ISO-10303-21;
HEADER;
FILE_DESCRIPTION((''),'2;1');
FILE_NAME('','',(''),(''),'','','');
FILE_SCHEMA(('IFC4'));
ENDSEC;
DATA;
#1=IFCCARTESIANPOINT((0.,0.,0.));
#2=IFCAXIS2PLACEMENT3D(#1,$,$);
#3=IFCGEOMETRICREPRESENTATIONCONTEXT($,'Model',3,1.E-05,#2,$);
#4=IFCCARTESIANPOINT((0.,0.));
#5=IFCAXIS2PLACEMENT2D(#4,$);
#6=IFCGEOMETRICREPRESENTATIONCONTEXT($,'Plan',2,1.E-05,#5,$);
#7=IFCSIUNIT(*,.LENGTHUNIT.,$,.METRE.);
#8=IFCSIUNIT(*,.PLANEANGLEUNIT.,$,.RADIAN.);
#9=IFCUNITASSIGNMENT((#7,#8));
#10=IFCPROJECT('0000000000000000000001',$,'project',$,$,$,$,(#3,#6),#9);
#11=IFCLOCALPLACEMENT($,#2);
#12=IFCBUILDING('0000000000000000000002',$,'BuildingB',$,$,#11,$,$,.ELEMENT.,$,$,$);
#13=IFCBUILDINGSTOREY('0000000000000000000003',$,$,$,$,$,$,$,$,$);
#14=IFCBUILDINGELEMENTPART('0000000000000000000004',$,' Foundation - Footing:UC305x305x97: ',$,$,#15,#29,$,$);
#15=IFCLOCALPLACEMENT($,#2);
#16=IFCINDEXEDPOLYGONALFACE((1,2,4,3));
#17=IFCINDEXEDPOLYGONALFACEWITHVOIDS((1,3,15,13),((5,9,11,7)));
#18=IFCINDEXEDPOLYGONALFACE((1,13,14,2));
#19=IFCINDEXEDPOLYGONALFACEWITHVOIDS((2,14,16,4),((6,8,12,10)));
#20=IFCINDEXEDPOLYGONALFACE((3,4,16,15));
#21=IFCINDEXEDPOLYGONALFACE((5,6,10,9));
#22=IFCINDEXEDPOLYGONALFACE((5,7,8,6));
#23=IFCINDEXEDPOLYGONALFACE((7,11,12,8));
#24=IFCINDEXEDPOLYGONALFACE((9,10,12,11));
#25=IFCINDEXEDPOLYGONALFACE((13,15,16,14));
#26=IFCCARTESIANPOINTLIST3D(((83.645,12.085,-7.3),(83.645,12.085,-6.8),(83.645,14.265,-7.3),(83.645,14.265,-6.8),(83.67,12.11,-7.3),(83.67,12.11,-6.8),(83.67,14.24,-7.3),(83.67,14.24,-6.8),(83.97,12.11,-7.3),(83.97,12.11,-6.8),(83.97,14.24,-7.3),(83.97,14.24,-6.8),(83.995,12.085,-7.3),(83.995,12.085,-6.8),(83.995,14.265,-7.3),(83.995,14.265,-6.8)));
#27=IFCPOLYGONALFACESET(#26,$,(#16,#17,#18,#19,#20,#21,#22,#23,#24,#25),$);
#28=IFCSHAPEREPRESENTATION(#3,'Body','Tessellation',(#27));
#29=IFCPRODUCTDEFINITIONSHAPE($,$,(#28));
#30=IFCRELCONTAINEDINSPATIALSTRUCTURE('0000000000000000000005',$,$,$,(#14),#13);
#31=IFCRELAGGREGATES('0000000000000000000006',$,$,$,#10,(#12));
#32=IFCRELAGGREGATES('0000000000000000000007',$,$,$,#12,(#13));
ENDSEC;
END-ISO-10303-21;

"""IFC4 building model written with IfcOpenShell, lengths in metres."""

from ifc_helpers import new_model, si_unit, origin, origin_2d, place, context, project, spatial, polyline, outline, extrude, element, save


model = new_model("IFC4")

# Units and contexts
model_context = context("Model", 3, precision=1e-05, world=origin())
plan_context = context("Plan", 2, precision=1e-05, world=origin_2d())
ifc_project = project(units=[si_unit("LENGTHUNIT", "METRE"), si_unit("PLANEANGLEUNIT", "RADIAN")], contexts=[model_context, plan_context])

# Building, storey
building_placement = place(None, origin())
building = spatial("IfcBuilding", under=ifc_project, at=building_placement, Name="BuildingB", CompositionType="ELEMENT")
storey = spatial("IfcBuildingStorey", under=building)

# Building element part, opening
building_element_part_1 = element("IfcBuildingElementPart", 1, inside=storey, Name=" Foundation - Footing:UC305x305x97: ", context=model_context, shape_type="SweptSolid", body=[
    extrude(outline(polyline([(83.995, 12.085, -7.3), (83.645, 12.085, -7.3), (83.645, 14.265, -7.3), (83.995, 14.265, -7.3), (83.995, 12.085, -7.3)])), None, (0.0, 0.0, 1.0), 0.5),
])
element("IfcOpeningElement", 2, inside=storey, cuts=building_element_part_1, context=model_context, shape_type="SweptSolid", body=[
    extrude(outline(polyline([(83.97, 12.11, -7.3), (83.67, 12.11, -7.3), (83.67, 14.24, -7.3), (83.97, 14.24, -7.3), (83.97, 12.11, -7.3)])), None, (0.0, 0.0, 1.0), 0.5),
])

save(model, "model.ifc")
